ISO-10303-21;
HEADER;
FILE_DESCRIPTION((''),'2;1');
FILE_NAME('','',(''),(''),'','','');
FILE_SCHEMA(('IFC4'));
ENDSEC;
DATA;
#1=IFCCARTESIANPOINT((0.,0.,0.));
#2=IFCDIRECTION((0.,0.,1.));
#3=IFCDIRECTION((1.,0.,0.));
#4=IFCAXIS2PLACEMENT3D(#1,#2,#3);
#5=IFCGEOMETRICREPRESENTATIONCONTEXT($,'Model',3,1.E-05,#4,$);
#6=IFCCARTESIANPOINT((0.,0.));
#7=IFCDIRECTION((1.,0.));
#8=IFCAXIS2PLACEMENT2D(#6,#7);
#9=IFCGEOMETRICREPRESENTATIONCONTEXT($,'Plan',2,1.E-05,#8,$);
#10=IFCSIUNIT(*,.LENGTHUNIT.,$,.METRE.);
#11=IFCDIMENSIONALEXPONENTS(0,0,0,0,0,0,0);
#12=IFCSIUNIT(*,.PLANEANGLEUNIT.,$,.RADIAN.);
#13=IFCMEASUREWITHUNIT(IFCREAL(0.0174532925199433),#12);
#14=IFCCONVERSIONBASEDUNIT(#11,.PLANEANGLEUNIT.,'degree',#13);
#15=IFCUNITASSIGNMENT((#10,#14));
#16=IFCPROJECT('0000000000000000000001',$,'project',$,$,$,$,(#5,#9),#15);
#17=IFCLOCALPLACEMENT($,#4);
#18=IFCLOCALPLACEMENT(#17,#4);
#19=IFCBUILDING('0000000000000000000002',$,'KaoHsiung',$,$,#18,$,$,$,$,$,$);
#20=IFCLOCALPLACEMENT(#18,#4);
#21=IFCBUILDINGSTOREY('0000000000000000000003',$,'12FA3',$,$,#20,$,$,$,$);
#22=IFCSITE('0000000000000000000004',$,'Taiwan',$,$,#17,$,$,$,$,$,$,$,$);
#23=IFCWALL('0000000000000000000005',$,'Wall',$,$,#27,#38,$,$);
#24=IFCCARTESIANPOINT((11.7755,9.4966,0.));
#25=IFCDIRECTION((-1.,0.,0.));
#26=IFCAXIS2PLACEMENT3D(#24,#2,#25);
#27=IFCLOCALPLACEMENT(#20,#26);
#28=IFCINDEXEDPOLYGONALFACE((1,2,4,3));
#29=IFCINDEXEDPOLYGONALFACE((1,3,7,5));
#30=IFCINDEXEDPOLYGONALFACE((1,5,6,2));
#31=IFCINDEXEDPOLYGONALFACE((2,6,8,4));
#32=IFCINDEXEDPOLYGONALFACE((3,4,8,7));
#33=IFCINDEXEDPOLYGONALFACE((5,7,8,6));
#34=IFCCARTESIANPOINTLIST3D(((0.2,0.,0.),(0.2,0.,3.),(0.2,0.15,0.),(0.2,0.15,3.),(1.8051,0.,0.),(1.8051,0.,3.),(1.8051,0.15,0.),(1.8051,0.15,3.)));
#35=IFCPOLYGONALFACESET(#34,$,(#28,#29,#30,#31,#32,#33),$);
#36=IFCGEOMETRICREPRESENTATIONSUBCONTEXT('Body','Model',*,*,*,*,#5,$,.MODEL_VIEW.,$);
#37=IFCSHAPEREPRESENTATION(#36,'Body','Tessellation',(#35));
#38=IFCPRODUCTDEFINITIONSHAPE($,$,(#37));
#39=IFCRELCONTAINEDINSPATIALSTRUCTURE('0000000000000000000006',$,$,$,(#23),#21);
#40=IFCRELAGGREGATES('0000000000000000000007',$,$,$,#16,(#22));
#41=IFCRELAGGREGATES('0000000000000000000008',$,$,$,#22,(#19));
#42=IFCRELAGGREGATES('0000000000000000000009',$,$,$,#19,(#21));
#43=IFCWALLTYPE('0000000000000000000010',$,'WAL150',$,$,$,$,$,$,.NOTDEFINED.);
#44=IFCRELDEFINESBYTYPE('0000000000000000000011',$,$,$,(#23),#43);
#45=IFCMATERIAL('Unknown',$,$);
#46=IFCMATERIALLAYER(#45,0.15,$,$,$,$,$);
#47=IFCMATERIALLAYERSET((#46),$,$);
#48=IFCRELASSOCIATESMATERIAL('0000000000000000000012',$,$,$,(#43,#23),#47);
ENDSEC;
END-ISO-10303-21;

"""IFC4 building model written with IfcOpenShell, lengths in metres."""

from ifc_helpers import new_model, entity, si_unit, converted_unit, frame, origin_with_axes, origin_2d_with_axis, place, context, subcontext, project, spatial, line, indexed_curve, outline, extrude, material, layer, layer_set, layer_usage, type_object, element, save


model = new_model("IFC4")

# Units and contexts
model_context = context("Model", 3, precision=1e-05, world=origin_with_axes())
plan_context = context("Plan", 2, precision=1e-05, world=origin_2d_with_axis())
body_context = subcontext(model_context, "Body", "Model", "MODEL_VIEW")
ifc_project = project(units=[si_unit("LENGTHUNIT", "METRE"), converted_unit("PLANEANGLEUNIT", "degree", entity("IfcReal", 0.0174532925199433), si_unit("PLANEANGLEUNIT", "RADIAN"), dimensions=[0, 0, 0, 0, 0, 0, 0])], contexts=[model_context, plan_context])

# Site, building, storey
site_placement = place(None, origin_with_axes())
site = spatial("IfcSite", under=ifc_project, at=site_placement, Name="Taiwan")
building_placement = place(site_placement, origin_with_axes())
building = spatial("IfcBuilding", under=site, at=building_placement, Name="KaoHsiung")
storey_placement = place(building_placement, origin_with_axes())
storey = spatial("IfcBuildingStorey", under=building, at=storey_placement, Name="12FA3")

# Shared definitions
ifc_material = material(Name="Unknown")

# Wall
ifc_layer_1 = layer(ifc_material, 0.15)
ifc_layer_set_1 = layer_set([ifc_layer_1])
wall_type_1 = type_object("IfcWallType", Name="WAL150", PredefinedType="NOTDEFINED", material=ifc_layer_set_1)
ifc_layer_usage_1 = layer_usage(ifc_layer_set_1, "AXIS2", "POSITIVE", 0.0)
wall_1_placement = place(storey_placement, frame((11.7755, 9.4966, 0.0), z_axis=(0.0, 0.0, 1.0), x_axis=(-1.0, 0.0, 0.0)))
element("IfcWall", 1, at=wall_1_placement, inside=storey, type_object=wall_type_1, material=ifc_layer_usage_1, Name="Wall", context=body_context, shape_type="SweptSolid", body=[
    extrude(outline(indexed_curve([(0.2, 0.0), (0.2, 0.15), (1.8051, 0.15), (1.8051, 0.0)], segments=[line(1, 2, 3, 4, 1)])), origin_with_axes(), (0.0, 0.0, 1.0), 3.0),
])

save(model, "model.ifc")
